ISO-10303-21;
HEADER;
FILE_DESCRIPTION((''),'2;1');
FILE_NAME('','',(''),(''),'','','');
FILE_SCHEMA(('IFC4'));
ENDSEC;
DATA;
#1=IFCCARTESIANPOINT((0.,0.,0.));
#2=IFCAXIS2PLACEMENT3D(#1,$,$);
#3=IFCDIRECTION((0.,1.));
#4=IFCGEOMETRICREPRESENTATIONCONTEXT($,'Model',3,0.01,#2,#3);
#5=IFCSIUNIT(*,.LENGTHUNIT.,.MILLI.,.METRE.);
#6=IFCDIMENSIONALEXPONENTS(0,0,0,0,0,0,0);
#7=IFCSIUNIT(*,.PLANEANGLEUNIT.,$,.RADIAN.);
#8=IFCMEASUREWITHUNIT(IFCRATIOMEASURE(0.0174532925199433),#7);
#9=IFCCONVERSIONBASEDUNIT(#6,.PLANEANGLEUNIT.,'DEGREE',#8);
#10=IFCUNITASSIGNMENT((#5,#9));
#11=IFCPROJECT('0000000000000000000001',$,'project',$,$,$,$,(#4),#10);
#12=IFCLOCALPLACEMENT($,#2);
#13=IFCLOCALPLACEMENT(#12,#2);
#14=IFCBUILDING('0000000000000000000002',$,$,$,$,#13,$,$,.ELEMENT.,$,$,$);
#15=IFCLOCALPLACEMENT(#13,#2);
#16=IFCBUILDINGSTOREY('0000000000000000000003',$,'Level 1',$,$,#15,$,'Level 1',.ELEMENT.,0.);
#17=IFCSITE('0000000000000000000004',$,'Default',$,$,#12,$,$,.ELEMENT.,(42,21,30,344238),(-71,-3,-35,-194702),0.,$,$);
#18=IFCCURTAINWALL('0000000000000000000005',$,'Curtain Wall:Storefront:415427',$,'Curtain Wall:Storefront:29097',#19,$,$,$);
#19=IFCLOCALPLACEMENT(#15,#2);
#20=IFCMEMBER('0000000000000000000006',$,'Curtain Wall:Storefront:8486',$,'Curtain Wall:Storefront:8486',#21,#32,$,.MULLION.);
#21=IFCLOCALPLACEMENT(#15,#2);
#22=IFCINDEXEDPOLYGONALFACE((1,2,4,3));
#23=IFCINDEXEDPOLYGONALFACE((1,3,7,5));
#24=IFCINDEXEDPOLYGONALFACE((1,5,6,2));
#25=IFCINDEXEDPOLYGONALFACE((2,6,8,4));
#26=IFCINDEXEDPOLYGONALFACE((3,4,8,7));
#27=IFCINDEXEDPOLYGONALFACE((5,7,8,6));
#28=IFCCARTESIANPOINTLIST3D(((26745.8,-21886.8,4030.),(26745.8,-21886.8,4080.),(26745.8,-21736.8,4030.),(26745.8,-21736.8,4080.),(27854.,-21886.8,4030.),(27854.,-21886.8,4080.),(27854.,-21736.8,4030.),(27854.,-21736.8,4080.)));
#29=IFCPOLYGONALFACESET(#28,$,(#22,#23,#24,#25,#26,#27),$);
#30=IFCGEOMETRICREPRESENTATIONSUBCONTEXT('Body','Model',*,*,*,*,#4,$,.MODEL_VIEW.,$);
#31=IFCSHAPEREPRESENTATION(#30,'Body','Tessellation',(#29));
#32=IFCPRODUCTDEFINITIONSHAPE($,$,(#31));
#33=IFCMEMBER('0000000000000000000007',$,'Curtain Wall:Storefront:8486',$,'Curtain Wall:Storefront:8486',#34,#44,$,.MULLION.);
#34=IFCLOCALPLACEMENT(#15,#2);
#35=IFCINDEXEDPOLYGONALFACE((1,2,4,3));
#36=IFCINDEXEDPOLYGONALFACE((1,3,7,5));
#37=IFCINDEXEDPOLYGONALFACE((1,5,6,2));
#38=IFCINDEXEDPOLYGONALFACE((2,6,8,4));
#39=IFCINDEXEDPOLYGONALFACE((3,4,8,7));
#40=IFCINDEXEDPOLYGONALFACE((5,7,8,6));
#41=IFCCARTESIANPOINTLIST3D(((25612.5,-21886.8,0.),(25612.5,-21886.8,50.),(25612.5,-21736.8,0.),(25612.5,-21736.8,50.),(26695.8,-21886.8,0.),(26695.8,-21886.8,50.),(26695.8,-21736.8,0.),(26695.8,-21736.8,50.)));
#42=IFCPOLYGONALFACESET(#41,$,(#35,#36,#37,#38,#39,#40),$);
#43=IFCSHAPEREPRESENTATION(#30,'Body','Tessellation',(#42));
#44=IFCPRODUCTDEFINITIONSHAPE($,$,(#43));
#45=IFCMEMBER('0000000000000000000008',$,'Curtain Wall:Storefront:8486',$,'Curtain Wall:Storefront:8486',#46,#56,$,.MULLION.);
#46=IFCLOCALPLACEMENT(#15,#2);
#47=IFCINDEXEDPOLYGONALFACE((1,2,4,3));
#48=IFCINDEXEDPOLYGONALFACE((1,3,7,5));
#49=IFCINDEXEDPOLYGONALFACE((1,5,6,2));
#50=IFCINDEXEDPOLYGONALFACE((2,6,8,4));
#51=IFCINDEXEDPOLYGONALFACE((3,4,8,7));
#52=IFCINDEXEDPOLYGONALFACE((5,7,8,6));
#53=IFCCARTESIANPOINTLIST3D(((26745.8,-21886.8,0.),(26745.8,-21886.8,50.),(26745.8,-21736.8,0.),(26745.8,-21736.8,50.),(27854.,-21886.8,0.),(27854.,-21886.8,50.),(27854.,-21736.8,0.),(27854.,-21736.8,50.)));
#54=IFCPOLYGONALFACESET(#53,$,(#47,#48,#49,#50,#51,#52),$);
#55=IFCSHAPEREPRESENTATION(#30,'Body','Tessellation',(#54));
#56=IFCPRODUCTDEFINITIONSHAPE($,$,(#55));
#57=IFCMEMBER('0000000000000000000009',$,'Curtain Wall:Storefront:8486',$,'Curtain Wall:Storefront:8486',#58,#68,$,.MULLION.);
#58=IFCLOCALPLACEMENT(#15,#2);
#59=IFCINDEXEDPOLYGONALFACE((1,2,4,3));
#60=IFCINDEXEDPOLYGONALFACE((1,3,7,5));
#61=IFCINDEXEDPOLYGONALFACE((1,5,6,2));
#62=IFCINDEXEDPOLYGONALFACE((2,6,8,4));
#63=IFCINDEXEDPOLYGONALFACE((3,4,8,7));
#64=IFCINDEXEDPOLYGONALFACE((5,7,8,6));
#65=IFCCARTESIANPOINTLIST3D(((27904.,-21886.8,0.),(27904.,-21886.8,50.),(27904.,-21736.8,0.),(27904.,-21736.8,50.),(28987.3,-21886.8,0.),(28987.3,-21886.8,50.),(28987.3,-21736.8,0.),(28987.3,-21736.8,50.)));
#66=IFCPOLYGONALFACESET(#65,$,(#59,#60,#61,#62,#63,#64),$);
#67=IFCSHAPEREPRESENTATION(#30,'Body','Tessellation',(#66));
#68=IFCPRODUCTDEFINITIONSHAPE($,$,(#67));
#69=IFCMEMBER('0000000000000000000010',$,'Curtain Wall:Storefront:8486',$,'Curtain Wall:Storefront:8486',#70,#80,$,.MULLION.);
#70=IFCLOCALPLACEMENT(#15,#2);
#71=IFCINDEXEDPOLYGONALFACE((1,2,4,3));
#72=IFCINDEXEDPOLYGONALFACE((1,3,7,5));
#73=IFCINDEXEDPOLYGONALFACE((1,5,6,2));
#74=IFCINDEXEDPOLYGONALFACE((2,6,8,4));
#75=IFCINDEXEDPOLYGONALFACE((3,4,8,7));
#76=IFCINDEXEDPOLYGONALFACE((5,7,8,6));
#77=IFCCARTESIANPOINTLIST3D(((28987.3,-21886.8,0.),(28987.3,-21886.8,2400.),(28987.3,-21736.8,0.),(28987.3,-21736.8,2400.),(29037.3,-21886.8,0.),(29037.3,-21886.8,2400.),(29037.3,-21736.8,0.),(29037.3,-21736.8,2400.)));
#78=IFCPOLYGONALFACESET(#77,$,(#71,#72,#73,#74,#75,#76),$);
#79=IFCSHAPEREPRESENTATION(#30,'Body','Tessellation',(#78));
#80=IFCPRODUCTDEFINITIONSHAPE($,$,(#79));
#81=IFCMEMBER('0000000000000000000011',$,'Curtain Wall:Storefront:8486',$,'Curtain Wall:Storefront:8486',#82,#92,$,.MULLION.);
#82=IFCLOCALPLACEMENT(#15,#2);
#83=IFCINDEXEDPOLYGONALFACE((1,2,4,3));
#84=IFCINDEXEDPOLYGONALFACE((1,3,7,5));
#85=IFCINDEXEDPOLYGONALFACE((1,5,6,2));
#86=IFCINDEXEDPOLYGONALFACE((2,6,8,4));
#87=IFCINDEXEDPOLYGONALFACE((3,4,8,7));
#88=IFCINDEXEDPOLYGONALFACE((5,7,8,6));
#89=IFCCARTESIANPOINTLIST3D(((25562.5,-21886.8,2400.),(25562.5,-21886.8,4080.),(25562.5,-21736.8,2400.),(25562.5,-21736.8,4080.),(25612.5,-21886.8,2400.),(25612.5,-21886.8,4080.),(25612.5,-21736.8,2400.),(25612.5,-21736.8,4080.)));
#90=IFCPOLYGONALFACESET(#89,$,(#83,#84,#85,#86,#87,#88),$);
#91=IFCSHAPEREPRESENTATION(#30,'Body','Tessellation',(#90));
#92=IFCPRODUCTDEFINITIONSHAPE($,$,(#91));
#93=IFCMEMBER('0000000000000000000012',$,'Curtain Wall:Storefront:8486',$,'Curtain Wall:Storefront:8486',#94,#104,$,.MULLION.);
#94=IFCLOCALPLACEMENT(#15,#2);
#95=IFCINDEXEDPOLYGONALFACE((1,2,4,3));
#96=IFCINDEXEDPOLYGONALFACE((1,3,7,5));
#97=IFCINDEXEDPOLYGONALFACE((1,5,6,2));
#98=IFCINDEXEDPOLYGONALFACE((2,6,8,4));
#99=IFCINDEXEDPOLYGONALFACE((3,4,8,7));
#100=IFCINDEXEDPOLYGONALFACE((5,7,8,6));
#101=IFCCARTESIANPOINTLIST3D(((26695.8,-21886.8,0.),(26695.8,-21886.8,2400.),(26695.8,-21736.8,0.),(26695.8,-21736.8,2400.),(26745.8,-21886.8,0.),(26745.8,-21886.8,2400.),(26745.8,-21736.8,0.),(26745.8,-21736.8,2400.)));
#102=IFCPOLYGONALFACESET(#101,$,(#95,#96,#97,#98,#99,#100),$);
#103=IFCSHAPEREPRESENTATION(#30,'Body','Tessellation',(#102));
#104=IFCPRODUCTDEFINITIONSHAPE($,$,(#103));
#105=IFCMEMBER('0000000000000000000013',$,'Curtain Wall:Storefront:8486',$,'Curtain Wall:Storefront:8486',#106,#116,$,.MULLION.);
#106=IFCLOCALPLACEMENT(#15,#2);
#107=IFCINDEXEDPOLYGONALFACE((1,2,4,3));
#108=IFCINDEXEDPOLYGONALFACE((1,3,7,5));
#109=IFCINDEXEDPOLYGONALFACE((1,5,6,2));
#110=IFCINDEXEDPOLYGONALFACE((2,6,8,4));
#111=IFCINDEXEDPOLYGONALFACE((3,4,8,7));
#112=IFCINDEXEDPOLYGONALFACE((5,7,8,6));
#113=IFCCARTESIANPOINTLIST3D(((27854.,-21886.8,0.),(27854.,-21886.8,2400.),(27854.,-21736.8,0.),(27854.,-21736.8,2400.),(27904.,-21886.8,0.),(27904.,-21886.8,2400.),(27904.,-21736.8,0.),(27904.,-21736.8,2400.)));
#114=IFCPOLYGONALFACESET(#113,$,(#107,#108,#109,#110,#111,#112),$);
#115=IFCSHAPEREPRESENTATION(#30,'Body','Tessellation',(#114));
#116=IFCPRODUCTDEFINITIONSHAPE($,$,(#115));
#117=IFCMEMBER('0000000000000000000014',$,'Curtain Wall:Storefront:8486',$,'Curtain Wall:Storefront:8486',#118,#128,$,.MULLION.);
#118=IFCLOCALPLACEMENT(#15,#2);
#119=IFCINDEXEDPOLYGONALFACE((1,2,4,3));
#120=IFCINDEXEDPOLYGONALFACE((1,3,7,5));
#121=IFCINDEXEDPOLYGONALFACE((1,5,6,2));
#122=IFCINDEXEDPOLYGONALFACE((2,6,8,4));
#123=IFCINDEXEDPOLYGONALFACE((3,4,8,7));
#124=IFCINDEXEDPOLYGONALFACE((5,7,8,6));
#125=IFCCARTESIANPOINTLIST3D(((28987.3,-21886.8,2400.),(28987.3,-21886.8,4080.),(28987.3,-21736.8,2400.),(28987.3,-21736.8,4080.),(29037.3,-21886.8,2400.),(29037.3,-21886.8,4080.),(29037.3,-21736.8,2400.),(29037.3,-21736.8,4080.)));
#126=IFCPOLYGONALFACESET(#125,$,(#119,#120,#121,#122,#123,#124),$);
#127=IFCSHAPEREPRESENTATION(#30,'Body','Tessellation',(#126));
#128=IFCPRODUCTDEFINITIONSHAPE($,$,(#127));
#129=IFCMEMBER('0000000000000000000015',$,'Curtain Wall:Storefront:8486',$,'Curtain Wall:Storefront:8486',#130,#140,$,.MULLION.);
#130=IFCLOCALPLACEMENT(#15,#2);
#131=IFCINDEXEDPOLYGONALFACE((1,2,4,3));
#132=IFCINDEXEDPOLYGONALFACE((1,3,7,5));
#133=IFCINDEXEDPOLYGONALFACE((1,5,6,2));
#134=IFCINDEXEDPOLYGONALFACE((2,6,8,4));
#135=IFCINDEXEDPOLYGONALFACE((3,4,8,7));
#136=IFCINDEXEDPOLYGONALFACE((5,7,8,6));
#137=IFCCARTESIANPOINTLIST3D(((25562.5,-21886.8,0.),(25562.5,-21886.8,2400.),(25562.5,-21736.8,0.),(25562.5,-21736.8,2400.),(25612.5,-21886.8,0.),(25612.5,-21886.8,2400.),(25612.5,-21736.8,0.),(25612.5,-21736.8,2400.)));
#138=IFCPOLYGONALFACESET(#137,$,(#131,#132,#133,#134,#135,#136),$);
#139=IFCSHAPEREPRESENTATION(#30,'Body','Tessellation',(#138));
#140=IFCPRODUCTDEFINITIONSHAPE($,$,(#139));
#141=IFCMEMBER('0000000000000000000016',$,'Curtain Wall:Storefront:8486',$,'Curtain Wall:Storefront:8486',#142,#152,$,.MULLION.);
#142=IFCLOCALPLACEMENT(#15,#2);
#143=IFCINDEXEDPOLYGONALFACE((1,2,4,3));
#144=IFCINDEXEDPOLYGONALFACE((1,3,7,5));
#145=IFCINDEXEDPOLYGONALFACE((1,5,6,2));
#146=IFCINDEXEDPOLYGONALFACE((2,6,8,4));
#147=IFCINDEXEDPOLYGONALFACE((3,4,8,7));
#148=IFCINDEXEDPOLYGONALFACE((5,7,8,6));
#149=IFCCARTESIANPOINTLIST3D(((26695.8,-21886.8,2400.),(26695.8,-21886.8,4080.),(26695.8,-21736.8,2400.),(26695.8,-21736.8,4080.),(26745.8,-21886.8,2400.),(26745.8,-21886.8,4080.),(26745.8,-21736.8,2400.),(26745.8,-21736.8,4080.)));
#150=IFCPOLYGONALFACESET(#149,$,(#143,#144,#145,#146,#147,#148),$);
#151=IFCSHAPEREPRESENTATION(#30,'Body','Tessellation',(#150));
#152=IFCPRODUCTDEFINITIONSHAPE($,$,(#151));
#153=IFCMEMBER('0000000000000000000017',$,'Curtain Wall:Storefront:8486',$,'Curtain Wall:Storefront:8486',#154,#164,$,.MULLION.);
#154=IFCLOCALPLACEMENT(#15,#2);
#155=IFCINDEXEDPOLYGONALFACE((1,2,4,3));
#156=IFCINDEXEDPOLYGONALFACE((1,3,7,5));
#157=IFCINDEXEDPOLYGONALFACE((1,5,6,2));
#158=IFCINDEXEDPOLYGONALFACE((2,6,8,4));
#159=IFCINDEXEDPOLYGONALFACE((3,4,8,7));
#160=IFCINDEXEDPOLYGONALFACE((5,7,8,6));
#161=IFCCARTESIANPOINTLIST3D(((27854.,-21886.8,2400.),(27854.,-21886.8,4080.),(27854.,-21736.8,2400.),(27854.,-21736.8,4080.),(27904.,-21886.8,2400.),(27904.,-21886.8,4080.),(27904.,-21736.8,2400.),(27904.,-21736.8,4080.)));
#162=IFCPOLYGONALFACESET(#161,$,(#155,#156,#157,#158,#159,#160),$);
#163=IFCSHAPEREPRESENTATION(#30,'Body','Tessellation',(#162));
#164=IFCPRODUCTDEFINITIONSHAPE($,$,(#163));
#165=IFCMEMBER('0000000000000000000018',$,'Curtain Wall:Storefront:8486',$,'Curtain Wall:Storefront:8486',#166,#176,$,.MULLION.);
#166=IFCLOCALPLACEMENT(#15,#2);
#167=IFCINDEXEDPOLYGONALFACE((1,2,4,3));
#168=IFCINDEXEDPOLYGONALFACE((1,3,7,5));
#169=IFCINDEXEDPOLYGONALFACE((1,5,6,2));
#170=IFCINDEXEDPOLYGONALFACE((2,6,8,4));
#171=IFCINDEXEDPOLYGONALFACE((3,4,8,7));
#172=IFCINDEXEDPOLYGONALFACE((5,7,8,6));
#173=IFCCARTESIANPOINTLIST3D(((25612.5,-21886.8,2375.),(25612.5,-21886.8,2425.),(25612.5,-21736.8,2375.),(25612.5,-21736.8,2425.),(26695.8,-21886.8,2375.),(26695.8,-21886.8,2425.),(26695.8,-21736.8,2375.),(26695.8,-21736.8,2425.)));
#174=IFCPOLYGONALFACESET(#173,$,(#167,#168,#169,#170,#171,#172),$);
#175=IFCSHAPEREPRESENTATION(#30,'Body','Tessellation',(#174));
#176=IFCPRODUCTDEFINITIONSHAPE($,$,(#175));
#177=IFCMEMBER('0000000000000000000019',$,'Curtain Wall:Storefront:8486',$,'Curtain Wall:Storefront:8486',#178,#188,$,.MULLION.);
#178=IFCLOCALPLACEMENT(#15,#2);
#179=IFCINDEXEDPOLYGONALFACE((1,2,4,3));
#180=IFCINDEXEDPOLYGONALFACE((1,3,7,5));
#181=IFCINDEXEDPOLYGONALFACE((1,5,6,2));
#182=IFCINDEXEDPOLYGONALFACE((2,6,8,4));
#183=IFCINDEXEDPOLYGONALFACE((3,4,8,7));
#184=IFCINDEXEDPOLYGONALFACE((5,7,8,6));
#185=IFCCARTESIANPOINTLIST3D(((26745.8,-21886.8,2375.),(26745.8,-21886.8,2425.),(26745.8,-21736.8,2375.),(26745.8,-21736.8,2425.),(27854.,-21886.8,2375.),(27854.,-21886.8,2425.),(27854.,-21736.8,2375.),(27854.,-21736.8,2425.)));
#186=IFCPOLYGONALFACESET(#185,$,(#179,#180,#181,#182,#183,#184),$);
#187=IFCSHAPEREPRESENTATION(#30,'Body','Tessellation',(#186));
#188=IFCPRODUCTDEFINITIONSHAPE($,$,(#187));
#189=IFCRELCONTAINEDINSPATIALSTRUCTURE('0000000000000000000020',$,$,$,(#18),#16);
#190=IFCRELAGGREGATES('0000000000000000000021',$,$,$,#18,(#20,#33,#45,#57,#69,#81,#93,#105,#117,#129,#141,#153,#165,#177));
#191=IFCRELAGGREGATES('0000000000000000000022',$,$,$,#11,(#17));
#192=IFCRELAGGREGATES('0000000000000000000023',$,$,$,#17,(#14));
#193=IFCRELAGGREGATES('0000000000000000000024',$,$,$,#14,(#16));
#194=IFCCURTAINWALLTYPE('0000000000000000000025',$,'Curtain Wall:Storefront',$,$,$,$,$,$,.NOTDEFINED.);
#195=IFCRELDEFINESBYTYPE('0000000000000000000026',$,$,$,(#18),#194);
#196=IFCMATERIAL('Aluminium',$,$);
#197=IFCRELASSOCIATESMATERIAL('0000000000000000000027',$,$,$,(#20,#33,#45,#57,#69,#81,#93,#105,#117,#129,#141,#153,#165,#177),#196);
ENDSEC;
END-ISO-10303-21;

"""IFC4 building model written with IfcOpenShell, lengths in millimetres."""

from ifc_helpers import new_model, entity, si_unit, converted_unit, direction, frame, frame_2d, origin, origin_2d_with_axis, place, context, subcontext, project, spatial, rectangle, extrude, material, type_object, element, aggregate, save


model = new_model("IFC4")

# Units and contexts
model_context = context("Model", 3, precision=0.01, world=origin(), true_north=direction((0.0, 1.0)))
body_context = subcontext(model_context, "Body", "Model", "MODEL_VIEW")
ifc_project = project(units=[si_unit("LENGTHUNIT", "METRE", prefix="MILLI"), converted_unit("PLANEANGLEUNIT", "DEGREE", entity("IfcRatioMeasure", 0.0174532925199433), si_unit("PLANEANGLEUNIT", "RADIAN"), dimensions=[0, 0, 0, 0, 0, 0, 0])], contexts=[model_context])

# Site, building, storey
site_placement = place(None, origin())
site = spatial("IfcSite", under=ifc_project, at=site_placement, Name="Default", CompositionType="ELEMENT", RefLatitude=(42, 21, 30, 344238), RefLongitude=(-71, -3, -35, -194702), RefElevation=0.0)
building_placement = place(site_placement, origin())
building = spatial("IfcBuilding", under=site, at=building_placement, CompositionType="ELEMENT")
storey_placement = place(building_placement, origin())
storey = spatial("IfcBuildingStorey", under=building, at=storey_placement, Name="Level 1", LongName="Level 1", CompositionType="ELEMENT", Elevation=0.0)

# Curtain wall, members
curtain_wall_type = type_object("IfcCurtainWallType", Name="Curtain Wall:Storefront", PredefinedType="NOTDEFINED")
ifc_material_1 = material(Name="Aluminium")
curtain_wall_1_placement = place(storey_placement, origin())
curtain_wall_1 = element("IfcCurtainWall", 1, at=curtain_wall_1_placement, inside=storey, type_object=curtain_wall_type, Name="Curtain Wall:Storefront:415427", ObjectType="Curtain Wall:Storefront:29097")
member_1_placement = place(curtain_wall_1_placement, origin())
member_1 = element("IfcMember", 2, at=member_1_placement, material=ifc_material_1, Name="Curtain Wall:Storefront:8486", ObjectType="Curtain Wall:Storefront:8486", PredefinedType="MULLION", context=body_context, shape_type="SweptSolid", body=[
    extrude(rectangle(XDim=50.0, YDim=150.0, at=frame_2d((0.0, 0.0), x_axis=(1.0, 0.0))), frame((27854.0, -21811.8, 4055.0), z_axis=(-1.0, 0.0, 0.0), x_axis=(0.0, 0.0, -1.0)), (0.0, 0.0, 1.0), 1108.3),
])
member_2_placement = place(curtain_wall_1_placement, origin())
member_2 = element("IfcMember", 3, at=member_2_placement, material=ifc_material_1, Name="Curtain Wall:Storefront:8486", ObjectType="Curtain Wall:Storefront:8486", PredefinedType="MULLION", context=body_context, shape_type="SweptSolid", body=[
    extrude(rectangle(XDim=50.0, YDim=150.0, at=frame_2d((0.0, 0.0), x_axis=(1.0, 0.0))), frame((25612.5, -21811.8, 25.0), z_axis=(1.0, 0.0, 0.0), x_axis=(0.0, 0.0, -1.0)), (0.0, 0.0, 1.0), 1083.3),
])
member_3_placement = place(curtain_wall_1_placement, origin())
member_3 = element("IfcMember", 4, at=member_3_placement, material=ifc_material_1, Name="Curtain Wall:Storefront:8486", ObjectType="Curtain Wall:Storefront:8486", PredefinedType="MULLION", context=body_context, shape_type="SweptSolid", body=[
    extrude(rectangle(XDim=50.0, YDim=150.0, at=frame_2d((0.0, 0.0), x_axis=(1.0, 0.0))), frame((26745.8, -21811.8, 25.0), z_axis=(1.0, 0.0, 0.0), x_axis=(0.0, 0.0, -1.0)), (0.0, 0.0, 1.0), 1108.3),
])
member_4_placement = place(curtain_wall_1_placement, origin())
member_4 = element("IfcMember", 5, at=member_4_placement, material=ifc_material_1, Name="Curtain Wall:Storefront:8486", ObjectType="Curtain Wall:Storefront:8486", PredefinedType="MULLION", context=body_context, shape_type="SweptSolid", body=[
    extrude(rectangle(XDim=50.0, YDim=150.0, at=frame_2d((0.0, 0.0), x_axis=(1.0, 0.0))), frame((27904.0, -21811.8, 25.0), z_axis=(1.0, 0.0, 0.0), x_axis=(0.0, 0.0, -1.0)), (0.0, 0.0, 1.0), 1083.3),
])
member_5_placement = place(curtain_wall_1_placement, origin())
member_5 = element("IfcMember", 6, at=member_5_placement, material=ifc_material_1, Name="Curtain Wall:Storefront:8486", ObjectType="Curtain Wall:Storefront:8486", PredefinedType="MULLION", context=body_context, shape_type="SweptSolid", body=[
    extrude(rectangle(XDim=50.0, YDim=150.0, at=frame_2d((0.0, 0.0), x_axis=(1.0, 0.0))), frame((29012.3, -21811.8, 0.0), z_axis=(0.0, 0.0, 1.0), x_axis=(-1.0, 0.0, 0.0)), (0.0, 0.0, 1.0), 2400.0),
])
member_6_placement = place(curtain_wall_1_placement, origin())
member_6 = element("IfcMember", 7, at=member_6_placement, material=ifc_material_1, Name="Curtain Wall:Storefront:8486", ObjectType="Curtain Wall:Storefront:8486", PredefinedType="MULLION", context=body_context, shape_type="SweptSolid", body=[
    extrude(rectangle(XDim=50.0, YDim=150.0, at=frame_2d((0.0, 0.0), x_axis=(1.0, 0.0))), frame((25587.5, -21811.8, 4080.0), z_axis=(0.0, 0.0, -1.0), x_axis=(-1.0, 0.0, 0.0)), (0.0, 0.0, 1.0), 1680.0),
])
member_7_placement = place(curtain_wall_1_placement, origin())
member_7 = element("IfcMember", 8, at=member_7_placement, material=ifc_material_1, Name="Curtain Wall:Storefront:8486", ObjectType="Curtain Wall:Storefront:8486", PredefinedType="MULLION", context=body_context, shape_type="SweptSolid", body=[
    extrude(rectangle(XDim=50.0, YDim=150.0, at=origin_2d_with_axis()), frame((26720.8, -21811.8, 0.0), z_axis=(0.0, 0.0, 1.0), x_axis=(-1.0, 0.0, 0.0)), (0.0, 0.0, 1.0), 2400.0),
])
member_8_placement = place(curtain_wall_1_placement, origin())
member_8 = element("IfcMember", 9, at=member_8_placement, material=ifc_material_1, Name="Curtain Wall:Storefront:8486", ObjectType="Curtain Wall:Storefront:8486", PredefinedType="MULLION", context=body_context, shape_type="SweptSolid", body=[
    extrude(rectangle(XDim=50.0, YDim=150.0, at=origin_2d_with_axis()), frame((27879.0, -21811.8, 0.0), z_axis=(0.0, 0.0, 1.0), x_axis=(-1.0, 0.0, 0.0)), (0.0, 0.0, 1.0), 2400.0),
])
member_9_placement = place(curtain_wall_1_placement, origin())
member_9 = element("IfcMember", 10, at=member_9_placement, material=ifc_material_1, Name="Curtain Wall:Storefront:8486", ObjectType="Curtain Wall:Storefront:8486", PredefinedType="MULLION", context=body_context, shape_type="SweptSolid", body=[
    extrude(rectangle(XDim=50.0, YDim=150.0, at=frame_2d((0.0, 0.0), x_axis=(1.0, 0.0))), frame((29012.3, -21811.8, 2400.0), z_axis=(0.0, 0.0, 1.0), x_axis=(-1.0, 0.0, 0.0)), (0.0, 0.0, 1.0), 1680.0),
])
member_10_placement = place(curtain_wall_1_placement, origin())
member_10 = element("IfcMember", 11, at=member_10_placement, material=ifc_material_1, Name="Curtain Wall:Storefront:8486", ObjectType="Curtain Wall:Storefront:8486", PredefinedType="MULLION", context=body_context, shape_type="SweptSolid", body=[
    extrude(rectangle(XDim=50.0, YDim=150.0, at=frame_2d((0.0, 0.0), x_axis=(1.0, 0.0))), frame((25587.5, -21811.8, 2400.0), z_axis=(0.0, 0.0, -1.0), x_axis=(-1.0, 0.0, 0.0)), (0.0, 0.0, 1.0), 2400.0),
])
member_11_placement = place(curtain_wall_1_placement, origin())
member_11 = element("IfcMember", 12, at=member_11_placement, material=ifc_material_1, Name="Curtain Wall:Storefront:8486", ObjectType="Curtain Wall:Storefront:8486", PredefinedType="MULLION", context=body_context, shape_type="SweptSolid", body=[
    extrude(rectangle(XDim=50.0, YDim=150.0, at=origin_2d_with_axis()), frame((26720.8, -21811.8, 2400.0), z_axis=(0.0, 0.0, 1.0), x_axis=(-1.0, 0.0, 0.0)), (0.0, 0.0, 1.0), 1680.0),
])
member_12_placement = place(curtain_wall_1_placement, origin())
member_12 = element("IfcMember", 13, at=member_12_placement, material=ifc_material_1, Name="Curtain Wall:Storefront:8486", ObjectType="Curtain Wall:Storefront:8486", PredefinedType="MULLION", context=body_context, shape_type="SweptSolid", body=[
    extrude(rectangle(XDim=50.0, YDim=150.0, at=origin_2d_with_axis()), frame((27879.0, -21811.8, 2400.0), z_axis=(0.0, 0.0, 1.0), x_axis=(-1.0, 0.0, 0.0)), (0.0, 0.0, 1.0), 1680.0),
])
member_13_placement = place(curtain_wall_1_placement, origin())
member_13 = element("IfcMember", 14, at=member_13_placement, material=ifc_material_1, Name="Curtain Wall:Storefront:8486", ObjectType="Curtain Wall:Storefront:8486", PredefinedType="MULLION", context=body_context, shape_type="SweptSolid", body=[
    extrude(rectangle(XDim=50.0, YDim=150.0, at=frame_2d((0.0, 0.0), x_axis=(1.0, 0.0))), frame((26695.8, -21811.8, 2400.0), z_axis=(-1.0, 0.0, 0.0), x_axis=(0.0, 0.0, -1.0)), (0.0, 0.0, 1.0), 1083.3),
])
member_14_placement = place(curtain_wall_1_placement, origin())
member_14 = element("IfcMember", 15, at=member_14_placement, material=ifc_material_1, Name="Curtain Wall:Storefront:8486", ObjectType="Curtain Wall:Storefront:8486", PredefinedType="MULLION", context=body_context, shape_type="SweptSolid", body=[
    extrude(rectangle(XDim=50.0, YDim=150.0, at=frame_2d((0.0, 0.0), x_axis=(1.0, 0.0))), frame((27854.0, -21811.8, 2400.0), z_axis=(-1.0, 0.0, 0.0), x_axis=(0.0, 0.0, -1.0)), (0.0, 0.0, 1.0), 1108.3),
])
aggregate(curtain_wall_1, [member_1, member_2, member_3, member_4, member_5, member_6, member_7, member_8, member_9, member_10, member_11, member_12, member_13, member_14])

save(model, "model.ifc")
